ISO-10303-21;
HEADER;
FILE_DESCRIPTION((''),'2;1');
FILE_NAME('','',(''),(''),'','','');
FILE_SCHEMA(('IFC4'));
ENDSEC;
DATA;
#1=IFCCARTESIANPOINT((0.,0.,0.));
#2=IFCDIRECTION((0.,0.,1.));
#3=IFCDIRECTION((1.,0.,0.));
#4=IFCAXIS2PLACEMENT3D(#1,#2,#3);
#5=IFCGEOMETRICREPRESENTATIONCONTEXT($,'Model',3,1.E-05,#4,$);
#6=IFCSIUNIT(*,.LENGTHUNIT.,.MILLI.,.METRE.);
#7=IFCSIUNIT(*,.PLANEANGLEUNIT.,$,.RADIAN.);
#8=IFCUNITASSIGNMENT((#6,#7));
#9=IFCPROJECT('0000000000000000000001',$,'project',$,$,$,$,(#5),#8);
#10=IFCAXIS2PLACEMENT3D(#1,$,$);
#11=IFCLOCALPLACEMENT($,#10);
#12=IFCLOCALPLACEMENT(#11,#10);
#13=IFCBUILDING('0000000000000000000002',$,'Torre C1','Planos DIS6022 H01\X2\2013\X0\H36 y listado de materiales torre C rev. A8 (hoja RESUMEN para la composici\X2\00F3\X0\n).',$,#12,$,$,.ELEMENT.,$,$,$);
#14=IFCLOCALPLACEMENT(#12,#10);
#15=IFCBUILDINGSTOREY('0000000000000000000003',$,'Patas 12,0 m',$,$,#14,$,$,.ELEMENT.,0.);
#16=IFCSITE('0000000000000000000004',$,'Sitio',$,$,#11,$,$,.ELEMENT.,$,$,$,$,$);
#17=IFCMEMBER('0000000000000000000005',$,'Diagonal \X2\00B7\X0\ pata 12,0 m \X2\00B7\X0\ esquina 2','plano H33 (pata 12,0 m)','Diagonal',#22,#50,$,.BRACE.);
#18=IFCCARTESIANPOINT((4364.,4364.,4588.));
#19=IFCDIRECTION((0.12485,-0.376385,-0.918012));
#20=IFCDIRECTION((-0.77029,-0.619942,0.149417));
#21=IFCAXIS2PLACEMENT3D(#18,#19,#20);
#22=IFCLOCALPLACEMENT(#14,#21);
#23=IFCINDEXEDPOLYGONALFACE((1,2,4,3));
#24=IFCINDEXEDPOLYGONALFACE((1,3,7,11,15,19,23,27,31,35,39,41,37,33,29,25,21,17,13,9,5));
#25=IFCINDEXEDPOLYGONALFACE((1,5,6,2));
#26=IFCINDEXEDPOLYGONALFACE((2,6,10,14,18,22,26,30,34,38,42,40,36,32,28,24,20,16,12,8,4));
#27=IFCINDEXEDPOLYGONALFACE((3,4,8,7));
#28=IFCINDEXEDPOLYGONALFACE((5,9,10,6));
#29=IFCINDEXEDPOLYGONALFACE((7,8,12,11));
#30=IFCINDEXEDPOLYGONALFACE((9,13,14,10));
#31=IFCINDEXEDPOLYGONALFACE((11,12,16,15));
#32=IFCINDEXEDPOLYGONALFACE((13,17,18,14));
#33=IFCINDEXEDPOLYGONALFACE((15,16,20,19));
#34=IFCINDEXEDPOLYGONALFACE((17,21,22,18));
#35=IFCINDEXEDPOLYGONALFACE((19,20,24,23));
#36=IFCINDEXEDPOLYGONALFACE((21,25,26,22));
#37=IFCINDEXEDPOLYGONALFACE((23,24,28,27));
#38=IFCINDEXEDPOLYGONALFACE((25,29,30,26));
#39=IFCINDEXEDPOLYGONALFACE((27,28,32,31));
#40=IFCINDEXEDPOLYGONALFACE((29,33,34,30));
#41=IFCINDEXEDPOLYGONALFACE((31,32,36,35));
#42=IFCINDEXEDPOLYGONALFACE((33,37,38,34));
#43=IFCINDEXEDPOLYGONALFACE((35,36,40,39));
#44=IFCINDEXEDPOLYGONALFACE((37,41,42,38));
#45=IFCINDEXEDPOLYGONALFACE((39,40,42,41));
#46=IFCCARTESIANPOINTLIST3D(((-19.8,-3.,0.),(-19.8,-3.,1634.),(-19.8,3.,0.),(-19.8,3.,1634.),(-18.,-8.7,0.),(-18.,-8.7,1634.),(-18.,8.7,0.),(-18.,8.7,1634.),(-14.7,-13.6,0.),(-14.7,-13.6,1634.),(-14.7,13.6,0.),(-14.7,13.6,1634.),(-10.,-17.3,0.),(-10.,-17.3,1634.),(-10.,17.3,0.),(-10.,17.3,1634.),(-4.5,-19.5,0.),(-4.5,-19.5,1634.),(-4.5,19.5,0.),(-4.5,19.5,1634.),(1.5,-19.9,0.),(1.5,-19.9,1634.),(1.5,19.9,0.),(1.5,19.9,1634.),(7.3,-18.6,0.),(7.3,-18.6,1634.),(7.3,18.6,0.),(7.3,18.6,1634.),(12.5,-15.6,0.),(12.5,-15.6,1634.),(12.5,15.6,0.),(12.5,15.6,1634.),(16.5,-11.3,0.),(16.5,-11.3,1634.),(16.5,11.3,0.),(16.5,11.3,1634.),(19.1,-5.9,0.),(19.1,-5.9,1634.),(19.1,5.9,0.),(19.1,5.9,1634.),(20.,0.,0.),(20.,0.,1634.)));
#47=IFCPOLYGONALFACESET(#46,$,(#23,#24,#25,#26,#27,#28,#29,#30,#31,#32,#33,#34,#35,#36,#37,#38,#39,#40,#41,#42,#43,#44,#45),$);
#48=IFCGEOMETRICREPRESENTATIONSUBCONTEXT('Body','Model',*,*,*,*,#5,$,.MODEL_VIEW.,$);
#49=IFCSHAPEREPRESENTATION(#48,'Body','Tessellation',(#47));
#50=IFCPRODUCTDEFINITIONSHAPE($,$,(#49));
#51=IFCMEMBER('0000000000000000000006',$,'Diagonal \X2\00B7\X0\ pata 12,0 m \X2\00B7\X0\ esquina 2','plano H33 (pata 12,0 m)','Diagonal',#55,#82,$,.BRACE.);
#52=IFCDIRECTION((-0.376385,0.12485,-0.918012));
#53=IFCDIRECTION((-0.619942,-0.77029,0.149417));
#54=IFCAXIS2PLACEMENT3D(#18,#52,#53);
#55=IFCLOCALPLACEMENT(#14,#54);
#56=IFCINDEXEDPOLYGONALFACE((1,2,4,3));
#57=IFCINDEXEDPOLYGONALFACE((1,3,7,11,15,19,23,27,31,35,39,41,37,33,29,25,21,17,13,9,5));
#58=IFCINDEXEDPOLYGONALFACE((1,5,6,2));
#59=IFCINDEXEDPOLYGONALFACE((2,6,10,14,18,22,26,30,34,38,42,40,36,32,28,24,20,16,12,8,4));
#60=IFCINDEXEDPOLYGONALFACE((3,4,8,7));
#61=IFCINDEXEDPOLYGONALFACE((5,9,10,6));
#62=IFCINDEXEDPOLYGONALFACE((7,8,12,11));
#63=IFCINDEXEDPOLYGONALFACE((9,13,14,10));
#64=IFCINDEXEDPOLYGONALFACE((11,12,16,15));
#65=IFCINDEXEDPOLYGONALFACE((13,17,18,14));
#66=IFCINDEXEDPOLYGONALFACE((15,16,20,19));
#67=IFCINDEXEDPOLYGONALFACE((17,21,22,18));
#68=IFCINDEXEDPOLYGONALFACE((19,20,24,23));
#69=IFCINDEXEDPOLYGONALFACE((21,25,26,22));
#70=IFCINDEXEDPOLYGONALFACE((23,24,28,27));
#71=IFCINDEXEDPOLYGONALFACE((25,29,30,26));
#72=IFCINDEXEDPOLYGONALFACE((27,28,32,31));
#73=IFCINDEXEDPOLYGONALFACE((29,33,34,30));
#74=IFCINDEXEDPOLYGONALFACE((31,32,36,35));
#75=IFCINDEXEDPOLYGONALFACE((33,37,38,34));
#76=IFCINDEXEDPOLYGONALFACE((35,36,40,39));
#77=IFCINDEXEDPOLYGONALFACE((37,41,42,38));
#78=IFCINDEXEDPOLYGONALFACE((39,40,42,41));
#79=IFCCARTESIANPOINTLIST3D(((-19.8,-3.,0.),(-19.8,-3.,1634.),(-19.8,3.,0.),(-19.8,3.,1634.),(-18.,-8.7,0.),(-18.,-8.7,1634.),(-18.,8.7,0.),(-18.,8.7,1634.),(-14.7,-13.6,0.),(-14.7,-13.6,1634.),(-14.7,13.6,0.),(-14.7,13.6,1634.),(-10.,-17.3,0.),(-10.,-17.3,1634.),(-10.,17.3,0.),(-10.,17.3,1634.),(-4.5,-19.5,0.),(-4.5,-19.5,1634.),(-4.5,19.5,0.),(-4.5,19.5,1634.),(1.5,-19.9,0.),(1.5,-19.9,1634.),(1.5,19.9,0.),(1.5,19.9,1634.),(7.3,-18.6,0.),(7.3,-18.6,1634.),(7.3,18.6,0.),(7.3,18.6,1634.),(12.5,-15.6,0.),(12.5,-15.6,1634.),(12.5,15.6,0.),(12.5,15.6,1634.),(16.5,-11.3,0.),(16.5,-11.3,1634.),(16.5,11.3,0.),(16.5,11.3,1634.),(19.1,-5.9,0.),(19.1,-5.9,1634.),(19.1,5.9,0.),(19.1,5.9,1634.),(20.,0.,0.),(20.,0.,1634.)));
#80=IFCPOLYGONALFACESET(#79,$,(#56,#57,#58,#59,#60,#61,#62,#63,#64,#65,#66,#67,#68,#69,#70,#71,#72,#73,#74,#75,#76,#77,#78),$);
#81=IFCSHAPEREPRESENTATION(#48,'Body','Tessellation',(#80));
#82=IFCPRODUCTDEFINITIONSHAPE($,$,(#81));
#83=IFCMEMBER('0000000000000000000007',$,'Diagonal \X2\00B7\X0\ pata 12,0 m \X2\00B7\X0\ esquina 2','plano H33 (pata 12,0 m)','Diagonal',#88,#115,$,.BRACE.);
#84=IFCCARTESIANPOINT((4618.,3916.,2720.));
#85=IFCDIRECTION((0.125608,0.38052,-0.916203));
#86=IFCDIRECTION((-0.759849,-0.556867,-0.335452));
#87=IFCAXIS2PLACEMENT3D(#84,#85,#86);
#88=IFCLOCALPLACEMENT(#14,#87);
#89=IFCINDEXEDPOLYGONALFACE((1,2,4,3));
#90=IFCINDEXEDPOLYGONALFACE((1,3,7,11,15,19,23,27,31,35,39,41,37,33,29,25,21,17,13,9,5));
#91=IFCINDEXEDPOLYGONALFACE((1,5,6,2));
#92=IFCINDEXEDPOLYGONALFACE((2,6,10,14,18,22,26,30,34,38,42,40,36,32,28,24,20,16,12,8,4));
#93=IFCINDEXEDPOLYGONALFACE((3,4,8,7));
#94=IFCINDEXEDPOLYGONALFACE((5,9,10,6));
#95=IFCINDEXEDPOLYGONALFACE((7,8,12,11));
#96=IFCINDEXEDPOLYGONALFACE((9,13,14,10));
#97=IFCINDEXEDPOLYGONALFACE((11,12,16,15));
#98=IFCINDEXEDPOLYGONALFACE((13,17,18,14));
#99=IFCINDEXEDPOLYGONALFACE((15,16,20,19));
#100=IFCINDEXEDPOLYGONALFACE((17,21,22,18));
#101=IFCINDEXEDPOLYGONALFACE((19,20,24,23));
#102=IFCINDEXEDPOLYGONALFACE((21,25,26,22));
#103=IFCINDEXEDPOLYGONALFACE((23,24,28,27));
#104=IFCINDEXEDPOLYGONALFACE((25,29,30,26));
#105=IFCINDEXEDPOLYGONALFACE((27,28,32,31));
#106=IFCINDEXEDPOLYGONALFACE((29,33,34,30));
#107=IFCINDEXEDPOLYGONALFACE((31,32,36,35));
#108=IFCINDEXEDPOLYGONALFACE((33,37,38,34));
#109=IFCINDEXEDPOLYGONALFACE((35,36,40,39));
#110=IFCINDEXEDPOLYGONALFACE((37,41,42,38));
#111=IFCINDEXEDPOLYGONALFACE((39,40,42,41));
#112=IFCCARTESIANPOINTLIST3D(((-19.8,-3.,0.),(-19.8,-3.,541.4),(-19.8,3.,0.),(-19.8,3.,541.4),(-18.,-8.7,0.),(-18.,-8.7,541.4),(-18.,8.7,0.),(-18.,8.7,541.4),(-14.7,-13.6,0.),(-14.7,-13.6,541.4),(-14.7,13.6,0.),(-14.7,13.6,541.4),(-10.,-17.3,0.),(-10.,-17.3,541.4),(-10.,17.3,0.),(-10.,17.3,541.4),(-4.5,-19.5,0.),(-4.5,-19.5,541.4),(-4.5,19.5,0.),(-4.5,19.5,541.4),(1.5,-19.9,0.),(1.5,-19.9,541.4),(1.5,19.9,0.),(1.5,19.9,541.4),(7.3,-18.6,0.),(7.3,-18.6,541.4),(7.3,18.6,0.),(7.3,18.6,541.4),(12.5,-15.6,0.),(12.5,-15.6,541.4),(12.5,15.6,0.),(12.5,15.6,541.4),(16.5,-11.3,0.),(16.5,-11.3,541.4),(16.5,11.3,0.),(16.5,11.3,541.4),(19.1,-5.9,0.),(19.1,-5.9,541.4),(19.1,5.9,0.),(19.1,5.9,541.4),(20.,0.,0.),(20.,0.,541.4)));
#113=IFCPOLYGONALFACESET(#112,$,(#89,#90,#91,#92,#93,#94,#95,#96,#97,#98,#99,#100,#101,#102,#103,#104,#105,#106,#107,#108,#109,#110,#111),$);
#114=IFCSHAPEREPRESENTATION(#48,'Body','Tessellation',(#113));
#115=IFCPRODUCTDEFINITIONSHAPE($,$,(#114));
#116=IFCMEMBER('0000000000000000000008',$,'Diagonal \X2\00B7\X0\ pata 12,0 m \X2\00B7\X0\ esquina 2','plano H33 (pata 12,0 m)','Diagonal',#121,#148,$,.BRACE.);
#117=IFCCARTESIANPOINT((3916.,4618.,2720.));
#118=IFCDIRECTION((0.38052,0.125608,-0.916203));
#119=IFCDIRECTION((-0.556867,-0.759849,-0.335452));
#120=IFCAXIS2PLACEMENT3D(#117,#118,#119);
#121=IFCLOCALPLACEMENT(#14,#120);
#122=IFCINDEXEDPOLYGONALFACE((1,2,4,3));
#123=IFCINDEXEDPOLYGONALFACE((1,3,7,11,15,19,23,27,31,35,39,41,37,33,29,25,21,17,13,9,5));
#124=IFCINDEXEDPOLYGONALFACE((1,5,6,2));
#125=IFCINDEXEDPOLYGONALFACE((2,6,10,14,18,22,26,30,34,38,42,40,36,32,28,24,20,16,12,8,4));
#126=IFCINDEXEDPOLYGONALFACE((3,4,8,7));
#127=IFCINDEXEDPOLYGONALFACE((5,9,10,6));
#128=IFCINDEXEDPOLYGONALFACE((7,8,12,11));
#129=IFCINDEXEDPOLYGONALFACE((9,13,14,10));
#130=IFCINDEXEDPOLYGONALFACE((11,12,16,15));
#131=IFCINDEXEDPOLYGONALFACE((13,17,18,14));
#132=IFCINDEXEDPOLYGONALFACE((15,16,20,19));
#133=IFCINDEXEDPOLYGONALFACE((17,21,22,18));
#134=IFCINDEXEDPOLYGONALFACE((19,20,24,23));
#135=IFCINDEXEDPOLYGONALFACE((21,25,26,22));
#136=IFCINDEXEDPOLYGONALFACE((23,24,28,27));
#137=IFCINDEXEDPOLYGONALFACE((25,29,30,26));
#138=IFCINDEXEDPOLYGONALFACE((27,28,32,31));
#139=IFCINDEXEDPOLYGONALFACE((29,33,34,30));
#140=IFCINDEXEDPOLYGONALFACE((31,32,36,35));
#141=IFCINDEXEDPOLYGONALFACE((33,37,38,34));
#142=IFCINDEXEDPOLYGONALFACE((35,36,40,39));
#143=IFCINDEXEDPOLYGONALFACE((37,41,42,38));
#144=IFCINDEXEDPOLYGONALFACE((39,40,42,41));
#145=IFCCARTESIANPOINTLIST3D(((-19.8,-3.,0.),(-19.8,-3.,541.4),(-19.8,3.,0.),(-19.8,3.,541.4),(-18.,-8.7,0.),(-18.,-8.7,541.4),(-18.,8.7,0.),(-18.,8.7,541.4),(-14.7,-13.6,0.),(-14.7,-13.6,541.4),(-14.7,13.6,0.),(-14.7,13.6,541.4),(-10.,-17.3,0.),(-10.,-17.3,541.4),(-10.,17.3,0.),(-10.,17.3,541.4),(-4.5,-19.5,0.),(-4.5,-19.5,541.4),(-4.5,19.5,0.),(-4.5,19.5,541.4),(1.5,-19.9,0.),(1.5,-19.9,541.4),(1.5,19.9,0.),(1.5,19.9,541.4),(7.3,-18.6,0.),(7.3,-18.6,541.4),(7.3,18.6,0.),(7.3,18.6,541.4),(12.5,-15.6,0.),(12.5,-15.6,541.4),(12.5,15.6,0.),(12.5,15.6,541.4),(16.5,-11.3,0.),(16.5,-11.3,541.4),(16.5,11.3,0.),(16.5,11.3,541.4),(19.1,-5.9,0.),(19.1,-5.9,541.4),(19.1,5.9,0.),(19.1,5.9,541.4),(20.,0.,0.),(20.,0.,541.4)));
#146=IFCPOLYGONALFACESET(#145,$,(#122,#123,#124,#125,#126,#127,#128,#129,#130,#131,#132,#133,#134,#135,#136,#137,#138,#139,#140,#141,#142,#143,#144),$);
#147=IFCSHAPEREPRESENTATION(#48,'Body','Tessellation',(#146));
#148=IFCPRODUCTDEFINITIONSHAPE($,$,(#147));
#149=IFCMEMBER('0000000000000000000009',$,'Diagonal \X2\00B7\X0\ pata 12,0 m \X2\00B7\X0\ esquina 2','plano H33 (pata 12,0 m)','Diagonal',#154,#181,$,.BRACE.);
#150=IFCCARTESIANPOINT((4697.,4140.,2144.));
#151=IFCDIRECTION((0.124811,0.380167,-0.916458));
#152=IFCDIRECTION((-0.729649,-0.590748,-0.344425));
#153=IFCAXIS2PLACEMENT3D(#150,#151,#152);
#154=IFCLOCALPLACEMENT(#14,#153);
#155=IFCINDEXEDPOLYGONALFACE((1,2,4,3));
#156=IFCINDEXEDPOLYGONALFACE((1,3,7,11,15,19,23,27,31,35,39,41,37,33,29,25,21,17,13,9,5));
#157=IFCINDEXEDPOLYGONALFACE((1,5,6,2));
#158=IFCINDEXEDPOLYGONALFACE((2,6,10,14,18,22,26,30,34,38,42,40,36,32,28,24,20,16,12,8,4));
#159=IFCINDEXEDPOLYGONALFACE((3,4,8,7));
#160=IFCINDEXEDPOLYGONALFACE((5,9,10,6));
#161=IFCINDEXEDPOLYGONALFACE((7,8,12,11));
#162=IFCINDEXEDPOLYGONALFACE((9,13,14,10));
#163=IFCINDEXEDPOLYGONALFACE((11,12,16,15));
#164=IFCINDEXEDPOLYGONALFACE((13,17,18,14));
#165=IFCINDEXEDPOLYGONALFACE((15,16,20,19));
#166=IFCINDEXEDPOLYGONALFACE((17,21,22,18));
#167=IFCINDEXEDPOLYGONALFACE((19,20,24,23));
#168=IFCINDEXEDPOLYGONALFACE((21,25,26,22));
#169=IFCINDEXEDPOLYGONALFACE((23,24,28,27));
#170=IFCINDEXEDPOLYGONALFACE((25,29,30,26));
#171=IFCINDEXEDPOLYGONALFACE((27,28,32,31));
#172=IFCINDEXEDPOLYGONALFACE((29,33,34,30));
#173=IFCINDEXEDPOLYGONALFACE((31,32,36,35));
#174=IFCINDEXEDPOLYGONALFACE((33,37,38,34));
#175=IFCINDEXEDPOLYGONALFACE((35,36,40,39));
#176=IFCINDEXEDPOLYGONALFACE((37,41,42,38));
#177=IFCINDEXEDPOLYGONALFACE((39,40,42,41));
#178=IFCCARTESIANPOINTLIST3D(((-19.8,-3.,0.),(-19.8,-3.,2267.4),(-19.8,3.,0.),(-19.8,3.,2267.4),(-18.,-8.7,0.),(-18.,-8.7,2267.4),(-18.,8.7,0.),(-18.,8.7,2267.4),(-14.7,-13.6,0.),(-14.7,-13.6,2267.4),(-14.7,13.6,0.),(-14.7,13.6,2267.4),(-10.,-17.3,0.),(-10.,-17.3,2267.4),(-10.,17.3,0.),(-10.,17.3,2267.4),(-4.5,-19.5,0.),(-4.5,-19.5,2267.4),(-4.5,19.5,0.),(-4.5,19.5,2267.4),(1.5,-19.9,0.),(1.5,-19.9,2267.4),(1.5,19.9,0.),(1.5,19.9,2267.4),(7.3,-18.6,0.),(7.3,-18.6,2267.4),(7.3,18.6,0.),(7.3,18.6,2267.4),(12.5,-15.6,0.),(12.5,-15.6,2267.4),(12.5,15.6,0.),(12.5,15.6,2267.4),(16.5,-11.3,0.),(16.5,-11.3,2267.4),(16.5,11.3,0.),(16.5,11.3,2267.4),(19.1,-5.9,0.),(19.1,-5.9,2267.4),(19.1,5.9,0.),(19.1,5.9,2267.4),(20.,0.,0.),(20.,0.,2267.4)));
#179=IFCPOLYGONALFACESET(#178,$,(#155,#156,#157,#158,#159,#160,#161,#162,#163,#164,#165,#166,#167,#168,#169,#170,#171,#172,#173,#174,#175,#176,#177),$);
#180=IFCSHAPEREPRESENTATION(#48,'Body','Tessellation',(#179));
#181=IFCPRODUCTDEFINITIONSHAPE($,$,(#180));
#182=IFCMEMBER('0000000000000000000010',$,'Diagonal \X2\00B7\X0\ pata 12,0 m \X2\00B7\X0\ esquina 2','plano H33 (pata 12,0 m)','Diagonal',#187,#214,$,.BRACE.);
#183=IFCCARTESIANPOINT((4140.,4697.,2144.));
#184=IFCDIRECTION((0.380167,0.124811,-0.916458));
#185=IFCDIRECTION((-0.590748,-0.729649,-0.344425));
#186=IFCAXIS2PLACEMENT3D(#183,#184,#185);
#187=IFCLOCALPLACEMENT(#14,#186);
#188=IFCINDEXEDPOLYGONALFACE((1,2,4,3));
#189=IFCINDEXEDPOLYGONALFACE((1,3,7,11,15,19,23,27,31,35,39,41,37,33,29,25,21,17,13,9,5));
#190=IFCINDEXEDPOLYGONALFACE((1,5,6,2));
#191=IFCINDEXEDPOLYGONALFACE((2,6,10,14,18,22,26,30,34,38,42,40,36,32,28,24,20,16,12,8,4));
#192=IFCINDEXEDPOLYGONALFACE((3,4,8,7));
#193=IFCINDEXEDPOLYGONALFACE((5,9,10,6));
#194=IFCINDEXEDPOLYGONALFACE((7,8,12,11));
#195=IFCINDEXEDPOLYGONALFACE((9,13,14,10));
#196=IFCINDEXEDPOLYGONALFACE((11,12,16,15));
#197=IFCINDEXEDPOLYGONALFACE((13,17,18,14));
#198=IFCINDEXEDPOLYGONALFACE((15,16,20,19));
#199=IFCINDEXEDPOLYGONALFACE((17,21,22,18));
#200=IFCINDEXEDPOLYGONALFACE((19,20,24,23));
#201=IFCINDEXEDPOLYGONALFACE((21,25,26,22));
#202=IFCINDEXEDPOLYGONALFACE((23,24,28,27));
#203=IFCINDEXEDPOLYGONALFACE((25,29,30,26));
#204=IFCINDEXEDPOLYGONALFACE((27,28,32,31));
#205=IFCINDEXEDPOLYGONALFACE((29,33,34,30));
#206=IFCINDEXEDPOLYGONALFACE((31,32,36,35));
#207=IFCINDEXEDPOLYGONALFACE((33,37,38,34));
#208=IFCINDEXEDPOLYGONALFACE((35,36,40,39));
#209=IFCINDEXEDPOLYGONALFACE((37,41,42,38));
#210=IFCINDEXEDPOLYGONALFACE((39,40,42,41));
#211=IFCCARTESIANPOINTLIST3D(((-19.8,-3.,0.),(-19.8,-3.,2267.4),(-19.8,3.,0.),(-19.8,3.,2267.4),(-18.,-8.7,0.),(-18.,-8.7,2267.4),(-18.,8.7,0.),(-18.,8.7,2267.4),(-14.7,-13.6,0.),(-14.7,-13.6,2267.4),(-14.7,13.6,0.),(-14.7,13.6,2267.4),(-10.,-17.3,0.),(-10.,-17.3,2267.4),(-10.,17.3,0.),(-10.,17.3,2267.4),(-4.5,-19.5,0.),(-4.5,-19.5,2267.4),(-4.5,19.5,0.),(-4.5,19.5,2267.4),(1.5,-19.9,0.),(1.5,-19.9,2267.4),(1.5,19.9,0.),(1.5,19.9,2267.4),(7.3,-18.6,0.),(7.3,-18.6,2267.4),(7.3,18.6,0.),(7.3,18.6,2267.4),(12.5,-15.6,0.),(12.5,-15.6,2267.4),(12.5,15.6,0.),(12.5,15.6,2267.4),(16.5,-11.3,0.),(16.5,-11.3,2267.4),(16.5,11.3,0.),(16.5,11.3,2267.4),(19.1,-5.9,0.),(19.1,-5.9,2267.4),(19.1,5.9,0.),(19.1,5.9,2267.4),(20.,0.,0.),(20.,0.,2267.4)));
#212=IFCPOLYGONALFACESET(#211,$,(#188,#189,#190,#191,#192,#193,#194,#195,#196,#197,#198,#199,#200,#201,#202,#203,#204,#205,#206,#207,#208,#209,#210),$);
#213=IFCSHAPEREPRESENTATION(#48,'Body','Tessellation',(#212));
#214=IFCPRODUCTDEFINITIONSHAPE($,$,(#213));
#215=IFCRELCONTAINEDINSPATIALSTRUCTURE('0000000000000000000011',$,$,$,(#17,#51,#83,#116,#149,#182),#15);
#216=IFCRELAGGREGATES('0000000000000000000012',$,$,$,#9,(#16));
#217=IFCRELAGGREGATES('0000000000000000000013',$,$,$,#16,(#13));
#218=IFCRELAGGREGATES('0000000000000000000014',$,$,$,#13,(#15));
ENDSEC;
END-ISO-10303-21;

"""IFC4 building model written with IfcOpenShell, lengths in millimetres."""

from ifc_helpers import new_model, si_unit, frame, origin, origin_with_axes, place, context, subcontext, project, spatial, circle, extrude, element, save


model = new_model("IFC4")

# Units and contexts
model_context = context("Model", 3, precision=1e-05, world=origin_with_axes())
body_context = subcontext(model_context, "Body", "Model", "MODEL_VIEW")
ifc_project = project(units=[si_unit("LENGTHUNIT", "METRE", prefix="MILLI"), si_unit("PLANEANGLEUNIT", "RADIAN")], contexts=[model_context])

# Site, building, storey
site_placement = place(None, origin())
site = spatial("IfcSite", under=ifc_project, at=site_placement, Name="Sitio", CompositionType="ELEMENT")
building_placement = place(site_placement, origin())
building = spatial("IfcBuilding", under=site, at=building_placement, Name="Torre C1", Description="Planos DIS6022 H01–H36 y listado de materiales torre C rev. A8 (hoja RESUMEN para la composición).", CompositionType="ELEMENT")
storey_placement = place(building_placement, origin())
storey = spatial("IfcBuildingStorey", under=building, at=storey_placement, Name="Patas 12,0 m", CompositionType="ELEMENT", Elevation=0.0)

# Members
for number, where, z_axis, x_axis, name in (
    (1, (4364.0, 4364.0, 4588.0), (0.12485, -0.376385, -0.918012), (-0.77029, -0.619942, 0.149417), "Diagonal · pata 12,0 m · esquina 2"),
    (2, (4364.0, 4364.0, 4588.0), (-0.376385, 0.12485, -0.918012), (-0.619942, -0.77029, 0.149417), "Diagonal · pata 12,0 m · esquina 2"),
):
    element("IfcMember", number, at=place(storey_placement, frame(where, z_axis=z_axis, x_axis=x_axis)), inside=storey, Name=name, Description="plano H33 (pata 12,0 m)", ObjectType="Diagonal", PredefinedType="BRACE", context=body_context, shape_type="SweptSolid", body=[
        extrude(circle(Radius=20.0), None, (0.0, 0.0, 1.0), 1634.0),
    ])
for number, where, z_axis, x_axis, name in (
    (3, (4618.0, 3916.0, 2720.0), (0.125608, 0.38052, -0.916203), (-0.759849, -0.556867, -0.335452), "Diagonal · pata 12,0 m · esquina 2"),
    (4, (3916.0, 4618.0, 2720.0), (0.38052, 0.125608, -0.916203), (-0.556867, -0.759849, -0.335452), "Diagonal · pata 12,0 m · esquina 2"),
):
    element("IfcMember", number, at=place(storey_placement, frame(where, z_axis=z_axis, x_axis=x_axis)), inside=storey, Name=name, Description="plano H33 (pata 12,0 m)", ObjectType="Diagonal", PredefinedType="BRACE", context=body_context, shape_type="SweptSolid", body=[
        extrude(circle(Radius=20.0), None, (0.0, 0.0, 1.0), 541.4),
    ])
for number, where, z_axis, x_axis, name in (
    (5, (4697.0, 4140.0, 2144.0), (0.124811, 0.380167, -0.916458), (-0.729649, -0.590748, -0.344425), "Diagonal · pata 12,0 m · esquina 2"),
    (6, (4140.0, 4697.0, 2144.0), (0.380167, 0.124811, -0.916458), (-0.590748, -0.729649, -0.344425), "Diagonal · pata 12,0 m · esquina 2"),
):
    element("IfcMember", number, at=place(storey_placement, frame(where, z_axis=z_axis, x_axis=x_axis)), inside=storey, Name=name, Description="plano H33 (pata 12,0 m)", ObjectType="Diagonal", PredefinedType="BRACE", context=body_context, shape_type="SweptSolid", body=[
        extrude(circle(Radius=20.0), None, (0.0, 0.0, 1.0), 2267.4),
    ])

save(model, "model.ifc")
